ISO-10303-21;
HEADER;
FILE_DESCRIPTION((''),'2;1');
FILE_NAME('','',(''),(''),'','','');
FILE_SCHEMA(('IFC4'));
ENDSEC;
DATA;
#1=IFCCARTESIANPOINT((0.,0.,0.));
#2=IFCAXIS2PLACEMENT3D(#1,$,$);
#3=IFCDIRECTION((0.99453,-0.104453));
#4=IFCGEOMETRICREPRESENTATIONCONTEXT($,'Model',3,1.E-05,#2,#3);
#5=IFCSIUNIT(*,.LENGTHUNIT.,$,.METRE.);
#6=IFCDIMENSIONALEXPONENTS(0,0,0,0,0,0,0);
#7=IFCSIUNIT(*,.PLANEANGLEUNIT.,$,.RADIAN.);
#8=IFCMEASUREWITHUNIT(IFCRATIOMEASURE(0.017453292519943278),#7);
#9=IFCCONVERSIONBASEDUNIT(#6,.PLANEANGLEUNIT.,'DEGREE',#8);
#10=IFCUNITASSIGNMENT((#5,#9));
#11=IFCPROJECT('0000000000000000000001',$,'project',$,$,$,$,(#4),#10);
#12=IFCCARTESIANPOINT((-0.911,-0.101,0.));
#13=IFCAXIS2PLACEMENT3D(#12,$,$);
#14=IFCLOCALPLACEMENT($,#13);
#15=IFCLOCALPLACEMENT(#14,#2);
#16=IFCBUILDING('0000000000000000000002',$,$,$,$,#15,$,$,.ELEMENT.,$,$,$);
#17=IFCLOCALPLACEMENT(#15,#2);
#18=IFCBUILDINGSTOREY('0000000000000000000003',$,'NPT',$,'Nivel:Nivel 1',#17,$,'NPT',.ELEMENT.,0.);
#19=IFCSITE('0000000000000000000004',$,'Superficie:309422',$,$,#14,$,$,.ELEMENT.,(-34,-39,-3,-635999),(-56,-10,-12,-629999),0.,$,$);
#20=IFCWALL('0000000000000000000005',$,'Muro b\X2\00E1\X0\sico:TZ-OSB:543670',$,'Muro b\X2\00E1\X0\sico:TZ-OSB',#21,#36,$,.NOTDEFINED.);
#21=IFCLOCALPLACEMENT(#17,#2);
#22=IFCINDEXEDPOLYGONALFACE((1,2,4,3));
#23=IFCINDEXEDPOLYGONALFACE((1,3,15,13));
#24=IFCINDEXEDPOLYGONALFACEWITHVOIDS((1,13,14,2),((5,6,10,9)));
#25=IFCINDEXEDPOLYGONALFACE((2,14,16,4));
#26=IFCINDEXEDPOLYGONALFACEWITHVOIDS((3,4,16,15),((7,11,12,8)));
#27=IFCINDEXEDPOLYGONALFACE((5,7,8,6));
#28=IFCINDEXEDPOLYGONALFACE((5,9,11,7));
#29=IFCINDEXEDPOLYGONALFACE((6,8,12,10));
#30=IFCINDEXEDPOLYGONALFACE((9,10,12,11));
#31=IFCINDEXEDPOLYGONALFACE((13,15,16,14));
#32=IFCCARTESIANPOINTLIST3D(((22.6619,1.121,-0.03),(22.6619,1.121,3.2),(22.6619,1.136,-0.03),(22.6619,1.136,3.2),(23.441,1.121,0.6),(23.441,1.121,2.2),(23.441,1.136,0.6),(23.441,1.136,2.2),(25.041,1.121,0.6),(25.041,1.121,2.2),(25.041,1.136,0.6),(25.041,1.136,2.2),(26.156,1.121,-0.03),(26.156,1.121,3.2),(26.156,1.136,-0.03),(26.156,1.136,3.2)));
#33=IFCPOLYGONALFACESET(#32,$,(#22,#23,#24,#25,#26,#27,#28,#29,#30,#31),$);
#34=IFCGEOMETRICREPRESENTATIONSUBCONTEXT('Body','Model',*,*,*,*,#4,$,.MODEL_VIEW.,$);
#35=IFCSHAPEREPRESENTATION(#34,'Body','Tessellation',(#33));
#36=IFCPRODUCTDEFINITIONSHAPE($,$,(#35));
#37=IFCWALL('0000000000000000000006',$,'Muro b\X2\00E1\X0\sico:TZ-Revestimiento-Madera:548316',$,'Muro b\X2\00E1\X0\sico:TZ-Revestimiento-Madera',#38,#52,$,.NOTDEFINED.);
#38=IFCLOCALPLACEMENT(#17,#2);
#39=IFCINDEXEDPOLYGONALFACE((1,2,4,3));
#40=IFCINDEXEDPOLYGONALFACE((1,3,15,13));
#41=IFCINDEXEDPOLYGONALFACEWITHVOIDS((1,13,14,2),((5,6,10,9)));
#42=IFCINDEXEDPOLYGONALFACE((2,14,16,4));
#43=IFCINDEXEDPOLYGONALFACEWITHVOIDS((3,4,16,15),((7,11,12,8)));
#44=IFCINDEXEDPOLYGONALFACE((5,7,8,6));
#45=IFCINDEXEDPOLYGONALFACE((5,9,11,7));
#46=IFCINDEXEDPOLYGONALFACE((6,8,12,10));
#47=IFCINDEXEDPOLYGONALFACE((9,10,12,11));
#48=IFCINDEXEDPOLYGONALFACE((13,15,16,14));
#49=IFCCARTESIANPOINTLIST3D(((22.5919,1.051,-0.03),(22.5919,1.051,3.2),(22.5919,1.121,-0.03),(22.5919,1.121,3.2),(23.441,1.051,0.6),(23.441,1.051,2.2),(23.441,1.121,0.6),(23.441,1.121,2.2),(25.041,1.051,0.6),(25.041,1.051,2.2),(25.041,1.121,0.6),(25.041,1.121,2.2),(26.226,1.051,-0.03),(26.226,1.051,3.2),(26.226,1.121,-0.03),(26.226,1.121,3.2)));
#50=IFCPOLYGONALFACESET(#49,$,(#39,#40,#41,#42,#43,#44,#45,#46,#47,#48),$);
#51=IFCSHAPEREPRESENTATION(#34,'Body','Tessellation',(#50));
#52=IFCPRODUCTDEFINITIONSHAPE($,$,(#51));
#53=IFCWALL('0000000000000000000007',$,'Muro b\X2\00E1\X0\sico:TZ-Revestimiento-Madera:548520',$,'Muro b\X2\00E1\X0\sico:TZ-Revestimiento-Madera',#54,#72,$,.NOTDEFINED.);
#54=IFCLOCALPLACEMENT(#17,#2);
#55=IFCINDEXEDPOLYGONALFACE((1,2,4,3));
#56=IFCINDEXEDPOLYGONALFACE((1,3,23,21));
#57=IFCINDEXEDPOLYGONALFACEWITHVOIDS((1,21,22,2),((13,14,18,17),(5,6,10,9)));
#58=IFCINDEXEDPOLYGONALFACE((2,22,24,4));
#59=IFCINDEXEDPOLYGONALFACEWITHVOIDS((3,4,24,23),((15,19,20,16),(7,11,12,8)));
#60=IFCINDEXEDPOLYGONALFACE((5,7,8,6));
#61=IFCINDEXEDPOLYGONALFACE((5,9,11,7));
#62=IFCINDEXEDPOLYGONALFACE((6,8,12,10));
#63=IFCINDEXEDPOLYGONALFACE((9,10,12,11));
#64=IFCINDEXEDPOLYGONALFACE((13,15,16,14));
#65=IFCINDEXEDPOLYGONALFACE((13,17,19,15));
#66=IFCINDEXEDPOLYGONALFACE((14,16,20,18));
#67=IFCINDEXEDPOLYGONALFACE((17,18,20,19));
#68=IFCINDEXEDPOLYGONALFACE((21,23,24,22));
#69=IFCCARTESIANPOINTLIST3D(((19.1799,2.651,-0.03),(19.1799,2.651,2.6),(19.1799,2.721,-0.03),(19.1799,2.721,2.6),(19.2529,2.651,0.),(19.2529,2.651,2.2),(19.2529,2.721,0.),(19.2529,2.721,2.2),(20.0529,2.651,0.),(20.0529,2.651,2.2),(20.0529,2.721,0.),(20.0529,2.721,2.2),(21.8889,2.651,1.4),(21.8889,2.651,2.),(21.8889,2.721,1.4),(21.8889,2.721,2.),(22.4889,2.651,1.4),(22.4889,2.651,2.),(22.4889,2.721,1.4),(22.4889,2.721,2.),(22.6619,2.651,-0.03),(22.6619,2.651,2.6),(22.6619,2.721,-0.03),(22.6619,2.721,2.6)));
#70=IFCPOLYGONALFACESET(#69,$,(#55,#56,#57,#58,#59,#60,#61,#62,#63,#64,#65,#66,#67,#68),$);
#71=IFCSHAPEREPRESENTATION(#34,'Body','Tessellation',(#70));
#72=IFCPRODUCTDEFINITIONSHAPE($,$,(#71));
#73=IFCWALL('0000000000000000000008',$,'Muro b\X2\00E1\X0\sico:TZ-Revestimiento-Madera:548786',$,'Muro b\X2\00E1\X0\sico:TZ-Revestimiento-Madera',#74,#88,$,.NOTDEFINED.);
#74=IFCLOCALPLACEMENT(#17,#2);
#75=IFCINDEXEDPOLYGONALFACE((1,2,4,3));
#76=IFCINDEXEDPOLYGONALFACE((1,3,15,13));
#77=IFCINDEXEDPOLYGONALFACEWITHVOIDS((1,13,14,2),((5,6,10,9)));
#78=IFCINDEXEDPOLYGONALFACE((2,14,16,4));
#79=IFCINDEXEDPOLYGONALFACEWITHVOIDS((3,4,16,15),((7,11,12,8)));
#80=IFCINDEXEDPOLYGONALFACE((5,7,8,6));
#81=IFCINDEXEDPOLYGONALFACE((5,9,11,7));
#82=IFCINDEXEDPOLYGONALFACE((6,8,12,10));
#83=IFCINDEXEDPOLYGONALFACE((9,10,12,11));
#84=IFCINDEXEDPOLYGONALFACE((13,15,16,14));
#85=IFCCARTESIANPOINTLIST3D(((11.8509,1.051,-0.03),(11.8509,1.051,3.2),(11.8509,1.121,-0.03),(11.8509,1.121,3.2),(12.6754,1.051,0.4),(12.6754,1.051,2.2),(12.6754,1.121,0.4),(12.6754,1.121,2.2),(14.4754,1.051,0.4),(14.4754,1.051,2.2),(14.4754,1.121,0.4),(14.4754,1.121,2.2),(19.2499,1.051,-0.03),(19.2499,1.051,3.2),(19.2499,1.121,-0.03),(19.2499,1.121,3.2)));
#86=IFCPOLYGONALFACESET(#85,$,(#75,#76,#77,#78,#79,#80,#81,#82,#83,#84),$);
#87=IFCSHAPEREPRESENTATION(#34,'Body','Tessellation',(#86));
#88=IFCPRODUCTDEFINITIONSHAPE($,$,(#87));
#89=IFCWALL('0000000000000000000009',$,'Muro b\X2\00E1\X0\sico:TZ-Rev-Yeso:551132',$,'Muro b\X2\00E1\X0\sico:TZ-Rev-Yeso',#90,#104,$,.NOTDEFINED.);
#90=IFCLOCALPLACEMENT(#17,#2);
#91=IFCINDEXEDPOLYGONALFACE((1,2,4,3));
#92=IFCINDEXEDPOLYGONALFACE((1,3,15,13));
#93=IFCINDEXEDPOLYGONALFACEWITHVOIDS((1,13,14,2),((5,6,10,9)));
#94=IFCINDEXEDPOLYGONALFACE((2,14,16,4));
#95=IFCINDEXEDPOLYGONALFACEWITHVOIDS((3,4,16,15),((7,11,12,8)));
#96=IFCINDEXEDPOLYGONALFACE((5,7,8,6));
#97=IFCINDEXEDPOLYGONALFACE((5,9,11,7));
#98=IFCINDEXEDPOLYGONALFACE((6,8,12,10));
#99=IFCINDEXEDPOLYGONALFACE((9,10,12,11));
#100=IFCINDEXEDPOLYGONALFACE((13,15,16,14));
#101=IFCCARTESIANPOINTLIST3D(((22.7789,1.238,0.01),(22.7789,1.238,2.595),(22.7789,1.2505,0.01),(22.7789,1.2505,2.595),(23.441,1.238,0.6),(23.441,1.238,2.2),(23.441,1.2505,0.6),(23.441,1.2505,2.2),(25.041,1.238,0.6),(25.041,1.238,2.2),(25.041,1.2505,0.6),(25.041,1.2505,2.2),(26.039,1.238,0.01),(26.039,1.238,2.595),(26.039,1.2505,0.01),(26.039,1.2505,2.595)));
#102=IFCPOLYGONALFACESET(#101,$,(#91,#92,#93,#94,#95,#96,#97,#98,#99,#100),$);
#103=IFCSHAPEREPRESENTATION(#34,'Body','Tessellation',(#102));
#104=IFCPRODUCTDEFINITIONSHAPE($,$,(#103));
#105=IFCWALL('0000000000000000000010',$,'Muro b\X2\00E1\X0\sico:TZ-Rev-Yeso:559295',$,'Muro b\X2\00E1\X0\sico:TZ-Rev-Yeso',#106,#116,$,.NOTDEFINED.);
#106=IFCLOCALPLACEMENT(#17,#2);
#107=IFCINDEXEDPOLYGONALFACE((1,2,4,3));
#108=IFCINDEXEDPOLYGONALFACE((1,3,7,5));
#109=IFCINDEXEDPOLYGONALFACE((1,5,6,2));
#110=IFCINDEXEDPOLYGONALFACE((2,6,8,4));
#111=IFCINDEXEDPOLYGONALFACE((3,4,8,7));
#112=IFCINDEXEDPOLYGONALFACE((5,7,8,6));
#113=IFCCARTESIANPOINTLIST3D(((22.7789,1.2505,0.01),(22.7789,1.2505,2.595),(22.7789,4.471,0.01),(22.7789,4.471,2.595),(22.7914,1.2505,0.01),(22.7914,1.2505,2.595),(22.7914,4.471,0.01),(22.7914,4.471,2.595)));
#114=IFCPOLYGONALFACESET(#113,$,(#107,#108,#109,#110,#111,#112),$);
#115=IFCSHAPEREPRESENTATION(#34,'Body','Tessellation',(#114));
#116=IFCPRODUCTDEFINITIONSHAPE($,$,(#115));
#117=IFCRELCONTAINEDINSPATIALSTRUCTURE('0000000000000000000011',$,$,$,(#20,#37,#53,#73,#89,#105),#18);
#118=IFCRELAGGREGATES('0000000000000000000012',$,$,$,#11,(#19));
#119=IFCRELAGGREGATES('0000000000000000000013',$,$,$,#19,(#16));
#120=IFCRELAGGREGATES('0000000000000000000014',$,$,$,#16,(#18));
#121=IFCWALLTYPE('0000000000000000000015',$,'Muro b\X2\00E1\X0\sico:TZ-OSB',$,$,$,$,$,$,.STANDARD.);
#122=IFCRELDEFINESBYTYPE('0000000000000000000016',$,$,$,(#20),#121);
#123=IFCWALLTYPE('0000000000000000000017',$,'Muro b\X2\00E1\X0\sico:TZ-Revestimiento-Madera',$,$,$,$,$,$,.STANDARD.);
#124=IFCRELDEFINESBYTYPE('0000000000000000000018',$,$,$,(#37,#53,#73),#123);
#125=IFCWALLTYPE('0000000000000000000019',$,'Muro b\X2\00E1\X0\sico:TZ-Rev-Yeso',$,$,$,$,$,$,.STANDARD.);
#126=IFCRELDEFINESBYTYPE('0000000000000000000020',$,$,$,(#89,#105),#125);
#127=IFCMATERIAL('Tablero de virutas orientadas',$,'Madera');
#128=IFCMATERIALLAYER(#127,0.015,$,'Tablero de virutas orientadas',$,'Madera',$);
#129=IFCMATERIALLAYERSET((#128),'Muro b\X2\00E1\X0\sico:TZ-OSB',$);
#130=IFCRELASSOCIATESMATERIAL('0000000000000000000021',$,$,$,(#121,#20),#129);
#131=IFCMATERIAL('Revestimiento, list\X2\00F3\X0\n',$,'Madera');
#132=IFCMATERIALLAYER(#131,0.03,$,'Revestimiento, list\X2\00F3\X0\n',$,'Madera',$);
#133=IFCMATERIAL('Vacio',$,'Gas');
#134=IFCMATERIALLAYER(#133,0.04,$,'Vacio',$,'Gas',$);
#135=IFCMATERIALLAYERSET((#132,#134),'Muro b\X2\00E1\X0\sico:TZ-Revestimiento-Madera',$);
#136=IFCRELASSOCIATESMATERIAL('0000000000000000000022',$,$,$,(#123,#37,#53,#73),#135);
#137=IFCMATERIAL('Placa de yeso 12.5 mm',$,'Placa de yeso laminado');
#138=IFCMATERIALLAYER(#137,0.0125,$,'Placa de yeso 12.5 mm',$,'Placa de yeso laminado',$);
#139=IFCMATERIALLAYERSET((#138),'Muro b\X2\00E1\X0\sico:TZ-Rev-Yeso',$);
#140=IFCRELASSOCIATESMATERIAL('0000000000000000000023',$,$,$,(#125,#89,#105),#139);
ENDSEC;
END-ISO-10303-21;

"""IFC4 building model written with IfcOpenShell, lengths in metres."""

from ifc_helpers import new_model, entity, si_unit, converted_unit, direction, frame, frame_2d, origin, origin_2d_with_axis, place, context, subcontext, project, spatial, rectangle, extrude, material, layer, layer_set, layer_usage, type_object, element, save


model = new_model("IFC4")

# Units and contexts
model_context = context("Model", 3, precision=1e-05, world=origin(), true_north=direction((0.99453, -0.104453)))
body_context = subcontext(model_context, "Body", "Model", "MODEL_VIEW")
ifc_project = project(units=[si_unit("LENGTHUNIT", "METRE"), converted_unit("PLANEANGLEUNIT", "DEGREE", entity("IfcRatioMeasure", 0.017453292519943278), si_unit("PLANEANGLEUNIT", "RADIAN"), dimensions=[0, 0, 0, 0, 0, 0, 0])], contexts=[model_context])

# Site, building, storey
site_placement = place(None, frame((-0.911, -0.101, 0.0)))
site = spatial("IfcSite", under=ifc_project, at=site_placement, Name="Superficie:309422", CompositionType="ELEMENT", RefLatitude=(-34, -39, -3, -635999), RefLongitude=(-56, -10, -12, -629999), RefElevation=0.0)
building_placement = place(site_placement, origin())
building = spatial("IfcBuilding", under=site, at=building_placement, CompositionType="ELEMENT")
storey_placement = place(building_placement, origin())
storey = spatial("IfcBuildingStorey", under=building, at=storey_placement, Name="NPT", ObjectType="Nivel:Nivel 1", LongName="NPT", CompositionType="ELEMENT", Elevation=0.0)

# Walls, openings
ifc_material_1 = material(Name="Tablero de virutas orientadas", Category="Madera")
ifc_layer_1 = layer(ifc_material_1, 0.015, Name="Tablero de virutas orientadas", Category="Madera")
ifc_layer_set_1 = layer_set([ifc_layer_1], Name="Muro básico:TZ-OSB")
ifc_layer_usage_1 = layer_usage(ifc_layer_set_1, "AXIS2", "NEGATIVE", 0.0075)
wall_type_1 = type_object("IfcWallType", Name="Muro básico:TZ-OSB", PredefinedType="STANDARD", material=ifc_layer_set_1)
wall_1_placement = place(storey_placement, frame((26.156, 1.1285, -0.03), z_axis=(0.0, 0.0, 1.0), x_axis=(-1.0, 0.0, 0.0)))
wall_1 = element("IfcWall", 1, at=wall_1_placement, inside=storey, type_object=wall_type_1, material=ifc_layer_usage_1, Name="Muro básico:TZ-OSB:543670", ObjectType="Muro básico:TZ-OSB", PredefinedType="NOTDEFINED", context=body_context, shape_type="SweptSolid", body=[
    extrude(rectangle(XDim=3.494, YDim=0.015, at=frame_2d((1.747, 0.0), x_axis=(-1.0, 0.0))), origin(), (0.0, 0.0, 1.0), 3.23),
])
opening_1_placement = place(wall_1_placement, frame((2.715, 1.4145, 0.63)))
element("IfcOpeningElement", 2, at=opening_1_placement, cuts=wall_1, PredefinedType="OPENING", context=body_context, shape_type="SweptSolid", body=[
    extrude(rectangle(XDim=1.6, YDim=1.6, at=frame_2d((0.0, 0.0), x_axis=(1.0, 0.0))), frame((-0.8, -3.048, 0.8), z_axis=(0.0, 1.0, 0.0), x_axis=(0.0, 0.0, 1.0)), (0.0, 0.0, 1.0), 3.048),
])
ifc_material_2 = material(Name="Revestimiento, listón", Category="Madera")
ifc_layer_2 = layer(ifc_material_2, 0.03, Name="Revestimiento, listón", Category="Madera")
ifc_material_3 = material(Name="Vacio", Category="Gas")
ifc_layer_3 = layer(ifc_material_3, 0.04, Name="Vacio", Category="Gas")
ifc_layer_set_2 = layer_set([ifc_layer_2, ifc_layer_3], Name="Muro básico:TZ-Revestimiento-Madera")
ifc_layer_usage_2 = layer_usage(ifc_layer_set_2, "AXIS2", "NEGATIVE", 0.035)
wall_type_2 = type_object("IfcWallType", Name="Muro básico:TZ-Revestimiento-Madera", PredefinedType="STANDARD", material=ifc_layer_set_2)
wall_2_placement = place(storey_placement, frame((26.226, 1.086, -0.03), z_axis=(0.0, 0.0, 1.0), x_axis=(-1.0, 0.0, 0.0)))
wall_2 = element("IfcWall", 3, at=wall_2_placement, inside=storey, type_object=wall_type_2, material=ifc_layer_usage_2, Name="Muro básico:TZ-Revestimiento-Madera:548316", ObjectType="Muro básico:TZ-Revestimiento-Madera", PredefinedType="NOTDEFINED", context=body_context, shape_type="SweptSolid", body=[
    extrude(rectangle(XDim=3.634, YDim=0.07, at=frame_2d((1.817, 0.0), x_axis=(1.0, 0.0))), origin(), (0.0, 0.0, 1.0), 3.23),
])
opening_2_placement = place(wall_2_placement, frame((2.785, 1.372, 0.63)))
element("IfcOpeningElement", 4, at=opening_2_placement, cuts=wall_2, PredefinedType="OPENING", context=body_context, shape_type="SweptSolid", body=[
    extrude(rectangle(XDim=1.6, YDim=1.6, at=frame_2d((0.0, 0.0), x_axis=(1.0, 0.0))), frame((-0.8, -3.048, 0.8), z_axis=(0.0, 1.0, 0.0), x_axis=(0.0, 0.0, 1.0)), (0.0, 0.0, 1.0), 3.048),
])

# Wall, openings
ifc_layer_usage_3 = layer_usage(ifc_layer_set_2, "AXIS2", "NEGATIVE", 0.035)
wall_3_placement = place(storey_placement, frame((22.6619, 2.686, -0.03), z_axis=(0.0, 0.0, 1.0), x_axis=(-1.0, 0.0, 0.0)))
wall_3 = element("IfcWall", 5, at=wall_3_placement, inside=storey, type_object=wall_type_2, material=ifc_layer_usage_3, Name="Muro básico:TZ-Revestimiento-Madera:548520", ObjectType="Muro básico:TZ-Revestimiento-Madera", PredefinedType="NOTDEFINED", context=body_context, shape_type="SweptSolid", body=[
    extrude(rectangle(XDim=3.482, YDim=0.07, at=frame_2d((1.741, 0.0), x_axis=(1.0, 0.0))), origin(), (0.0, 0.0, 1.0), 2.63),
])
opening_3_placement = place(wall_3_placement, frame((3.409, 1.372, 0.03)))
element("IfcOpeningElement", 6, at=opening_3_placement, cuts=wall_3, PredefinedType="OPENING", context=body_context, shape_type="SweptSolid", body=[
    extrude(rectangle(XDim=2.2, YDim=0.8, at=origin_2d_with_axis()), frame((-0.4, -3.048, 1.1), z_axis=(0.0, 1.0, 0.0), x_axis=(0.0, 0.0, 1.0)), (0.0, 0.0, 1.0), 3.048),
])
opening_4_placement = place(wall_3_placement, frame((0.773, 1.372, 1.43)))
element("IfcOpeningElement", 7, at=opening_4_placement, cuts=wall_3, PredefinedType="OPENING", context=body_context, shape_type="SweptSolid", body=[
    extrude(rectangle(XDim=0.6, YDim=0.6, at=frame_2d((0.0, 0.0), x_axis=(1.0, 0.0))), frame((-0.3, -3.048, 0.3), z_axis=(0.0, 1.0, 0.0), x_axis=(0.0, 0.0, 1.0)), (0.0, 0.0, 1.0), 3.048),
])

# Walls, openings
ifc_layer_usage_4 = layer_usage(ifc_layer_set_2, "AXIS2", "NEGATIVE", 0.035)
wall_4_placement = place(storey_placement, frame((19.2499, 1.086, -0.03), z_axis=(0.0, 0.0, 1.0), x_axis=(-1.0, 0.0, 0.0)))
wall_4 = element("IfcWall", 8, at=wall_4_placement, inside=storey, type_object=wall_type_2, material=ifc_layer_usage_4, Name="Muro básico:TZ-Revestimiento-Madera:548786", ObjectType="Muro básico:TZ-Revestimiento-Madera", PredefinedType="NOTDEFINED", context=body_context, shape_type="SweptSolid", body=[
    extrude(rectangle(XDim=7.399, YDim=0.07, at=frame_2d((3.6995, 0.0), x_axis=(1.0, 0.0))), origin(), (0.0, 0.0, 1.0), 3.23),
])
opening_5_placement = place(wall_4_placement, frame((6.5745, 1.372, 0.43)))
element("IfcOpeningElement", 9, at=opening_5_placement, cuts=wall_4, PredefinedType="OPENING", context=body_context, shape_type="SweptSolid", body=[
    extrude(rectangle(XDim=1.8, YDim=1.8, at=frame_2d((0.0, 0.0), x_axis=(0.0, 1.0))), frame((-0.9, -3.048, 0.9), z_axis=(0.0, 1.0, 0.0), x_axis=(-1.0, 0.0, 0.0)), (0.0, 0.0, 1.0), 3.048),
])
ifc_material_4 = material(Name="Placa de yeso 12.5 mm", Category="Placa de yeso laminado")
ifc_layer_4 = layer(ifc_material_4, 0.0125, Name="Placa de yeso 12.5 mm", Category="Placa de yeso laminado")
ifc_layer_set_3 = layer_set([ifc_layer_4], Name="Muro básico:TZ-Rev-Yeso")
ifc_layer_usage_5 = layer_usage(ifc_layer_set_3, "AXIS2", "NEGATIVE", 0.0063)
wall_type_3 = type_object("IfcWallType", Name="Muro básico:TZ-Rev-Yeso", PredefinedType="STANDARD", material=ifc_layer_set_3)
wall_5_placement = place(storey_placement, frame((26.039, 1.2443, 0.01), z_axis=(0.0, 0.0, 1.0), x_axis=(-1.0, 0.0, 0.0)))
wall_5 = element("IfcWall", 10, at=wall_5_placement, inside=storey, type_object=wall_type_3, material=ifc_layer_usage_5, Name="Muro básico:TZ-Rev-Yeso:551132", ObjectType="Muro básico:TZ-Rev-Yeso", PredefinedType="NOTDEFINED", context=body_context, shape_type="SweptSolid", body=[
    extrude(rectangle(XDim=3.26, YDim=0.0125, at=frame_2d((1.63, 0.0), x_axis=(-1.0, 0.0))), origin(), (0.0, 0.0, 1.0), 2.585),
])
opening_6_placement = place(wall_5_placement, frame((2.598, 1.5303, 0.59)))
element("IfcOpeningElement", 11, at=opening_6_placement, cuts=wall_5, PredefinedType="OPENING", context=body_context, shape_type="SweptSolid", body=[
    extrude(rectangle(XDim=1.6, YDim=1.6, at=frame_2d((0.0, 0.0), x_axis=(1.0, 0.0))), frame((-0.8, -3.048, 0.8), z_axis=(0.0, 1.0, 0.0), x_axis=(0.0, 0.0, 1.0)), (0.0, 0.0, 1.0), 3.048),
])

# Wall
ifc_layer_usage_6 = layer_usage(ifc_layer_set_3, "AXIS2", "NEGATIVE", 0.0063)
wall_6_placement = place(storey_placement, frame((22.7852, 1.2505, 0.01), z_axis=(0.0, 0.0, 1.0), x_axis=(0.0, 1.0, 0.0)))
element("IfcWall", 12, at=wall_6_placement, inside=storey, type_object=wall_type_3, material=ifc_layer_usage_6, Name="Muro básico:TZ-Rev-Yeso:559295", ObjectType="Muro básico:TZ-Rev-Yeso", PredefinedType="NOTDEFINED", context=body_context, shape_type="SweptSolid", body=[
    extrude(rectangle(XDim=3.2205, YDim=0.0125, at=frame_2d((1.6102, 0.0), x_axis=(-1.0, 0.0))), origin(), (0.0, 0.0, 1.0), 2.585),
])

save(model, "model.ifc")
